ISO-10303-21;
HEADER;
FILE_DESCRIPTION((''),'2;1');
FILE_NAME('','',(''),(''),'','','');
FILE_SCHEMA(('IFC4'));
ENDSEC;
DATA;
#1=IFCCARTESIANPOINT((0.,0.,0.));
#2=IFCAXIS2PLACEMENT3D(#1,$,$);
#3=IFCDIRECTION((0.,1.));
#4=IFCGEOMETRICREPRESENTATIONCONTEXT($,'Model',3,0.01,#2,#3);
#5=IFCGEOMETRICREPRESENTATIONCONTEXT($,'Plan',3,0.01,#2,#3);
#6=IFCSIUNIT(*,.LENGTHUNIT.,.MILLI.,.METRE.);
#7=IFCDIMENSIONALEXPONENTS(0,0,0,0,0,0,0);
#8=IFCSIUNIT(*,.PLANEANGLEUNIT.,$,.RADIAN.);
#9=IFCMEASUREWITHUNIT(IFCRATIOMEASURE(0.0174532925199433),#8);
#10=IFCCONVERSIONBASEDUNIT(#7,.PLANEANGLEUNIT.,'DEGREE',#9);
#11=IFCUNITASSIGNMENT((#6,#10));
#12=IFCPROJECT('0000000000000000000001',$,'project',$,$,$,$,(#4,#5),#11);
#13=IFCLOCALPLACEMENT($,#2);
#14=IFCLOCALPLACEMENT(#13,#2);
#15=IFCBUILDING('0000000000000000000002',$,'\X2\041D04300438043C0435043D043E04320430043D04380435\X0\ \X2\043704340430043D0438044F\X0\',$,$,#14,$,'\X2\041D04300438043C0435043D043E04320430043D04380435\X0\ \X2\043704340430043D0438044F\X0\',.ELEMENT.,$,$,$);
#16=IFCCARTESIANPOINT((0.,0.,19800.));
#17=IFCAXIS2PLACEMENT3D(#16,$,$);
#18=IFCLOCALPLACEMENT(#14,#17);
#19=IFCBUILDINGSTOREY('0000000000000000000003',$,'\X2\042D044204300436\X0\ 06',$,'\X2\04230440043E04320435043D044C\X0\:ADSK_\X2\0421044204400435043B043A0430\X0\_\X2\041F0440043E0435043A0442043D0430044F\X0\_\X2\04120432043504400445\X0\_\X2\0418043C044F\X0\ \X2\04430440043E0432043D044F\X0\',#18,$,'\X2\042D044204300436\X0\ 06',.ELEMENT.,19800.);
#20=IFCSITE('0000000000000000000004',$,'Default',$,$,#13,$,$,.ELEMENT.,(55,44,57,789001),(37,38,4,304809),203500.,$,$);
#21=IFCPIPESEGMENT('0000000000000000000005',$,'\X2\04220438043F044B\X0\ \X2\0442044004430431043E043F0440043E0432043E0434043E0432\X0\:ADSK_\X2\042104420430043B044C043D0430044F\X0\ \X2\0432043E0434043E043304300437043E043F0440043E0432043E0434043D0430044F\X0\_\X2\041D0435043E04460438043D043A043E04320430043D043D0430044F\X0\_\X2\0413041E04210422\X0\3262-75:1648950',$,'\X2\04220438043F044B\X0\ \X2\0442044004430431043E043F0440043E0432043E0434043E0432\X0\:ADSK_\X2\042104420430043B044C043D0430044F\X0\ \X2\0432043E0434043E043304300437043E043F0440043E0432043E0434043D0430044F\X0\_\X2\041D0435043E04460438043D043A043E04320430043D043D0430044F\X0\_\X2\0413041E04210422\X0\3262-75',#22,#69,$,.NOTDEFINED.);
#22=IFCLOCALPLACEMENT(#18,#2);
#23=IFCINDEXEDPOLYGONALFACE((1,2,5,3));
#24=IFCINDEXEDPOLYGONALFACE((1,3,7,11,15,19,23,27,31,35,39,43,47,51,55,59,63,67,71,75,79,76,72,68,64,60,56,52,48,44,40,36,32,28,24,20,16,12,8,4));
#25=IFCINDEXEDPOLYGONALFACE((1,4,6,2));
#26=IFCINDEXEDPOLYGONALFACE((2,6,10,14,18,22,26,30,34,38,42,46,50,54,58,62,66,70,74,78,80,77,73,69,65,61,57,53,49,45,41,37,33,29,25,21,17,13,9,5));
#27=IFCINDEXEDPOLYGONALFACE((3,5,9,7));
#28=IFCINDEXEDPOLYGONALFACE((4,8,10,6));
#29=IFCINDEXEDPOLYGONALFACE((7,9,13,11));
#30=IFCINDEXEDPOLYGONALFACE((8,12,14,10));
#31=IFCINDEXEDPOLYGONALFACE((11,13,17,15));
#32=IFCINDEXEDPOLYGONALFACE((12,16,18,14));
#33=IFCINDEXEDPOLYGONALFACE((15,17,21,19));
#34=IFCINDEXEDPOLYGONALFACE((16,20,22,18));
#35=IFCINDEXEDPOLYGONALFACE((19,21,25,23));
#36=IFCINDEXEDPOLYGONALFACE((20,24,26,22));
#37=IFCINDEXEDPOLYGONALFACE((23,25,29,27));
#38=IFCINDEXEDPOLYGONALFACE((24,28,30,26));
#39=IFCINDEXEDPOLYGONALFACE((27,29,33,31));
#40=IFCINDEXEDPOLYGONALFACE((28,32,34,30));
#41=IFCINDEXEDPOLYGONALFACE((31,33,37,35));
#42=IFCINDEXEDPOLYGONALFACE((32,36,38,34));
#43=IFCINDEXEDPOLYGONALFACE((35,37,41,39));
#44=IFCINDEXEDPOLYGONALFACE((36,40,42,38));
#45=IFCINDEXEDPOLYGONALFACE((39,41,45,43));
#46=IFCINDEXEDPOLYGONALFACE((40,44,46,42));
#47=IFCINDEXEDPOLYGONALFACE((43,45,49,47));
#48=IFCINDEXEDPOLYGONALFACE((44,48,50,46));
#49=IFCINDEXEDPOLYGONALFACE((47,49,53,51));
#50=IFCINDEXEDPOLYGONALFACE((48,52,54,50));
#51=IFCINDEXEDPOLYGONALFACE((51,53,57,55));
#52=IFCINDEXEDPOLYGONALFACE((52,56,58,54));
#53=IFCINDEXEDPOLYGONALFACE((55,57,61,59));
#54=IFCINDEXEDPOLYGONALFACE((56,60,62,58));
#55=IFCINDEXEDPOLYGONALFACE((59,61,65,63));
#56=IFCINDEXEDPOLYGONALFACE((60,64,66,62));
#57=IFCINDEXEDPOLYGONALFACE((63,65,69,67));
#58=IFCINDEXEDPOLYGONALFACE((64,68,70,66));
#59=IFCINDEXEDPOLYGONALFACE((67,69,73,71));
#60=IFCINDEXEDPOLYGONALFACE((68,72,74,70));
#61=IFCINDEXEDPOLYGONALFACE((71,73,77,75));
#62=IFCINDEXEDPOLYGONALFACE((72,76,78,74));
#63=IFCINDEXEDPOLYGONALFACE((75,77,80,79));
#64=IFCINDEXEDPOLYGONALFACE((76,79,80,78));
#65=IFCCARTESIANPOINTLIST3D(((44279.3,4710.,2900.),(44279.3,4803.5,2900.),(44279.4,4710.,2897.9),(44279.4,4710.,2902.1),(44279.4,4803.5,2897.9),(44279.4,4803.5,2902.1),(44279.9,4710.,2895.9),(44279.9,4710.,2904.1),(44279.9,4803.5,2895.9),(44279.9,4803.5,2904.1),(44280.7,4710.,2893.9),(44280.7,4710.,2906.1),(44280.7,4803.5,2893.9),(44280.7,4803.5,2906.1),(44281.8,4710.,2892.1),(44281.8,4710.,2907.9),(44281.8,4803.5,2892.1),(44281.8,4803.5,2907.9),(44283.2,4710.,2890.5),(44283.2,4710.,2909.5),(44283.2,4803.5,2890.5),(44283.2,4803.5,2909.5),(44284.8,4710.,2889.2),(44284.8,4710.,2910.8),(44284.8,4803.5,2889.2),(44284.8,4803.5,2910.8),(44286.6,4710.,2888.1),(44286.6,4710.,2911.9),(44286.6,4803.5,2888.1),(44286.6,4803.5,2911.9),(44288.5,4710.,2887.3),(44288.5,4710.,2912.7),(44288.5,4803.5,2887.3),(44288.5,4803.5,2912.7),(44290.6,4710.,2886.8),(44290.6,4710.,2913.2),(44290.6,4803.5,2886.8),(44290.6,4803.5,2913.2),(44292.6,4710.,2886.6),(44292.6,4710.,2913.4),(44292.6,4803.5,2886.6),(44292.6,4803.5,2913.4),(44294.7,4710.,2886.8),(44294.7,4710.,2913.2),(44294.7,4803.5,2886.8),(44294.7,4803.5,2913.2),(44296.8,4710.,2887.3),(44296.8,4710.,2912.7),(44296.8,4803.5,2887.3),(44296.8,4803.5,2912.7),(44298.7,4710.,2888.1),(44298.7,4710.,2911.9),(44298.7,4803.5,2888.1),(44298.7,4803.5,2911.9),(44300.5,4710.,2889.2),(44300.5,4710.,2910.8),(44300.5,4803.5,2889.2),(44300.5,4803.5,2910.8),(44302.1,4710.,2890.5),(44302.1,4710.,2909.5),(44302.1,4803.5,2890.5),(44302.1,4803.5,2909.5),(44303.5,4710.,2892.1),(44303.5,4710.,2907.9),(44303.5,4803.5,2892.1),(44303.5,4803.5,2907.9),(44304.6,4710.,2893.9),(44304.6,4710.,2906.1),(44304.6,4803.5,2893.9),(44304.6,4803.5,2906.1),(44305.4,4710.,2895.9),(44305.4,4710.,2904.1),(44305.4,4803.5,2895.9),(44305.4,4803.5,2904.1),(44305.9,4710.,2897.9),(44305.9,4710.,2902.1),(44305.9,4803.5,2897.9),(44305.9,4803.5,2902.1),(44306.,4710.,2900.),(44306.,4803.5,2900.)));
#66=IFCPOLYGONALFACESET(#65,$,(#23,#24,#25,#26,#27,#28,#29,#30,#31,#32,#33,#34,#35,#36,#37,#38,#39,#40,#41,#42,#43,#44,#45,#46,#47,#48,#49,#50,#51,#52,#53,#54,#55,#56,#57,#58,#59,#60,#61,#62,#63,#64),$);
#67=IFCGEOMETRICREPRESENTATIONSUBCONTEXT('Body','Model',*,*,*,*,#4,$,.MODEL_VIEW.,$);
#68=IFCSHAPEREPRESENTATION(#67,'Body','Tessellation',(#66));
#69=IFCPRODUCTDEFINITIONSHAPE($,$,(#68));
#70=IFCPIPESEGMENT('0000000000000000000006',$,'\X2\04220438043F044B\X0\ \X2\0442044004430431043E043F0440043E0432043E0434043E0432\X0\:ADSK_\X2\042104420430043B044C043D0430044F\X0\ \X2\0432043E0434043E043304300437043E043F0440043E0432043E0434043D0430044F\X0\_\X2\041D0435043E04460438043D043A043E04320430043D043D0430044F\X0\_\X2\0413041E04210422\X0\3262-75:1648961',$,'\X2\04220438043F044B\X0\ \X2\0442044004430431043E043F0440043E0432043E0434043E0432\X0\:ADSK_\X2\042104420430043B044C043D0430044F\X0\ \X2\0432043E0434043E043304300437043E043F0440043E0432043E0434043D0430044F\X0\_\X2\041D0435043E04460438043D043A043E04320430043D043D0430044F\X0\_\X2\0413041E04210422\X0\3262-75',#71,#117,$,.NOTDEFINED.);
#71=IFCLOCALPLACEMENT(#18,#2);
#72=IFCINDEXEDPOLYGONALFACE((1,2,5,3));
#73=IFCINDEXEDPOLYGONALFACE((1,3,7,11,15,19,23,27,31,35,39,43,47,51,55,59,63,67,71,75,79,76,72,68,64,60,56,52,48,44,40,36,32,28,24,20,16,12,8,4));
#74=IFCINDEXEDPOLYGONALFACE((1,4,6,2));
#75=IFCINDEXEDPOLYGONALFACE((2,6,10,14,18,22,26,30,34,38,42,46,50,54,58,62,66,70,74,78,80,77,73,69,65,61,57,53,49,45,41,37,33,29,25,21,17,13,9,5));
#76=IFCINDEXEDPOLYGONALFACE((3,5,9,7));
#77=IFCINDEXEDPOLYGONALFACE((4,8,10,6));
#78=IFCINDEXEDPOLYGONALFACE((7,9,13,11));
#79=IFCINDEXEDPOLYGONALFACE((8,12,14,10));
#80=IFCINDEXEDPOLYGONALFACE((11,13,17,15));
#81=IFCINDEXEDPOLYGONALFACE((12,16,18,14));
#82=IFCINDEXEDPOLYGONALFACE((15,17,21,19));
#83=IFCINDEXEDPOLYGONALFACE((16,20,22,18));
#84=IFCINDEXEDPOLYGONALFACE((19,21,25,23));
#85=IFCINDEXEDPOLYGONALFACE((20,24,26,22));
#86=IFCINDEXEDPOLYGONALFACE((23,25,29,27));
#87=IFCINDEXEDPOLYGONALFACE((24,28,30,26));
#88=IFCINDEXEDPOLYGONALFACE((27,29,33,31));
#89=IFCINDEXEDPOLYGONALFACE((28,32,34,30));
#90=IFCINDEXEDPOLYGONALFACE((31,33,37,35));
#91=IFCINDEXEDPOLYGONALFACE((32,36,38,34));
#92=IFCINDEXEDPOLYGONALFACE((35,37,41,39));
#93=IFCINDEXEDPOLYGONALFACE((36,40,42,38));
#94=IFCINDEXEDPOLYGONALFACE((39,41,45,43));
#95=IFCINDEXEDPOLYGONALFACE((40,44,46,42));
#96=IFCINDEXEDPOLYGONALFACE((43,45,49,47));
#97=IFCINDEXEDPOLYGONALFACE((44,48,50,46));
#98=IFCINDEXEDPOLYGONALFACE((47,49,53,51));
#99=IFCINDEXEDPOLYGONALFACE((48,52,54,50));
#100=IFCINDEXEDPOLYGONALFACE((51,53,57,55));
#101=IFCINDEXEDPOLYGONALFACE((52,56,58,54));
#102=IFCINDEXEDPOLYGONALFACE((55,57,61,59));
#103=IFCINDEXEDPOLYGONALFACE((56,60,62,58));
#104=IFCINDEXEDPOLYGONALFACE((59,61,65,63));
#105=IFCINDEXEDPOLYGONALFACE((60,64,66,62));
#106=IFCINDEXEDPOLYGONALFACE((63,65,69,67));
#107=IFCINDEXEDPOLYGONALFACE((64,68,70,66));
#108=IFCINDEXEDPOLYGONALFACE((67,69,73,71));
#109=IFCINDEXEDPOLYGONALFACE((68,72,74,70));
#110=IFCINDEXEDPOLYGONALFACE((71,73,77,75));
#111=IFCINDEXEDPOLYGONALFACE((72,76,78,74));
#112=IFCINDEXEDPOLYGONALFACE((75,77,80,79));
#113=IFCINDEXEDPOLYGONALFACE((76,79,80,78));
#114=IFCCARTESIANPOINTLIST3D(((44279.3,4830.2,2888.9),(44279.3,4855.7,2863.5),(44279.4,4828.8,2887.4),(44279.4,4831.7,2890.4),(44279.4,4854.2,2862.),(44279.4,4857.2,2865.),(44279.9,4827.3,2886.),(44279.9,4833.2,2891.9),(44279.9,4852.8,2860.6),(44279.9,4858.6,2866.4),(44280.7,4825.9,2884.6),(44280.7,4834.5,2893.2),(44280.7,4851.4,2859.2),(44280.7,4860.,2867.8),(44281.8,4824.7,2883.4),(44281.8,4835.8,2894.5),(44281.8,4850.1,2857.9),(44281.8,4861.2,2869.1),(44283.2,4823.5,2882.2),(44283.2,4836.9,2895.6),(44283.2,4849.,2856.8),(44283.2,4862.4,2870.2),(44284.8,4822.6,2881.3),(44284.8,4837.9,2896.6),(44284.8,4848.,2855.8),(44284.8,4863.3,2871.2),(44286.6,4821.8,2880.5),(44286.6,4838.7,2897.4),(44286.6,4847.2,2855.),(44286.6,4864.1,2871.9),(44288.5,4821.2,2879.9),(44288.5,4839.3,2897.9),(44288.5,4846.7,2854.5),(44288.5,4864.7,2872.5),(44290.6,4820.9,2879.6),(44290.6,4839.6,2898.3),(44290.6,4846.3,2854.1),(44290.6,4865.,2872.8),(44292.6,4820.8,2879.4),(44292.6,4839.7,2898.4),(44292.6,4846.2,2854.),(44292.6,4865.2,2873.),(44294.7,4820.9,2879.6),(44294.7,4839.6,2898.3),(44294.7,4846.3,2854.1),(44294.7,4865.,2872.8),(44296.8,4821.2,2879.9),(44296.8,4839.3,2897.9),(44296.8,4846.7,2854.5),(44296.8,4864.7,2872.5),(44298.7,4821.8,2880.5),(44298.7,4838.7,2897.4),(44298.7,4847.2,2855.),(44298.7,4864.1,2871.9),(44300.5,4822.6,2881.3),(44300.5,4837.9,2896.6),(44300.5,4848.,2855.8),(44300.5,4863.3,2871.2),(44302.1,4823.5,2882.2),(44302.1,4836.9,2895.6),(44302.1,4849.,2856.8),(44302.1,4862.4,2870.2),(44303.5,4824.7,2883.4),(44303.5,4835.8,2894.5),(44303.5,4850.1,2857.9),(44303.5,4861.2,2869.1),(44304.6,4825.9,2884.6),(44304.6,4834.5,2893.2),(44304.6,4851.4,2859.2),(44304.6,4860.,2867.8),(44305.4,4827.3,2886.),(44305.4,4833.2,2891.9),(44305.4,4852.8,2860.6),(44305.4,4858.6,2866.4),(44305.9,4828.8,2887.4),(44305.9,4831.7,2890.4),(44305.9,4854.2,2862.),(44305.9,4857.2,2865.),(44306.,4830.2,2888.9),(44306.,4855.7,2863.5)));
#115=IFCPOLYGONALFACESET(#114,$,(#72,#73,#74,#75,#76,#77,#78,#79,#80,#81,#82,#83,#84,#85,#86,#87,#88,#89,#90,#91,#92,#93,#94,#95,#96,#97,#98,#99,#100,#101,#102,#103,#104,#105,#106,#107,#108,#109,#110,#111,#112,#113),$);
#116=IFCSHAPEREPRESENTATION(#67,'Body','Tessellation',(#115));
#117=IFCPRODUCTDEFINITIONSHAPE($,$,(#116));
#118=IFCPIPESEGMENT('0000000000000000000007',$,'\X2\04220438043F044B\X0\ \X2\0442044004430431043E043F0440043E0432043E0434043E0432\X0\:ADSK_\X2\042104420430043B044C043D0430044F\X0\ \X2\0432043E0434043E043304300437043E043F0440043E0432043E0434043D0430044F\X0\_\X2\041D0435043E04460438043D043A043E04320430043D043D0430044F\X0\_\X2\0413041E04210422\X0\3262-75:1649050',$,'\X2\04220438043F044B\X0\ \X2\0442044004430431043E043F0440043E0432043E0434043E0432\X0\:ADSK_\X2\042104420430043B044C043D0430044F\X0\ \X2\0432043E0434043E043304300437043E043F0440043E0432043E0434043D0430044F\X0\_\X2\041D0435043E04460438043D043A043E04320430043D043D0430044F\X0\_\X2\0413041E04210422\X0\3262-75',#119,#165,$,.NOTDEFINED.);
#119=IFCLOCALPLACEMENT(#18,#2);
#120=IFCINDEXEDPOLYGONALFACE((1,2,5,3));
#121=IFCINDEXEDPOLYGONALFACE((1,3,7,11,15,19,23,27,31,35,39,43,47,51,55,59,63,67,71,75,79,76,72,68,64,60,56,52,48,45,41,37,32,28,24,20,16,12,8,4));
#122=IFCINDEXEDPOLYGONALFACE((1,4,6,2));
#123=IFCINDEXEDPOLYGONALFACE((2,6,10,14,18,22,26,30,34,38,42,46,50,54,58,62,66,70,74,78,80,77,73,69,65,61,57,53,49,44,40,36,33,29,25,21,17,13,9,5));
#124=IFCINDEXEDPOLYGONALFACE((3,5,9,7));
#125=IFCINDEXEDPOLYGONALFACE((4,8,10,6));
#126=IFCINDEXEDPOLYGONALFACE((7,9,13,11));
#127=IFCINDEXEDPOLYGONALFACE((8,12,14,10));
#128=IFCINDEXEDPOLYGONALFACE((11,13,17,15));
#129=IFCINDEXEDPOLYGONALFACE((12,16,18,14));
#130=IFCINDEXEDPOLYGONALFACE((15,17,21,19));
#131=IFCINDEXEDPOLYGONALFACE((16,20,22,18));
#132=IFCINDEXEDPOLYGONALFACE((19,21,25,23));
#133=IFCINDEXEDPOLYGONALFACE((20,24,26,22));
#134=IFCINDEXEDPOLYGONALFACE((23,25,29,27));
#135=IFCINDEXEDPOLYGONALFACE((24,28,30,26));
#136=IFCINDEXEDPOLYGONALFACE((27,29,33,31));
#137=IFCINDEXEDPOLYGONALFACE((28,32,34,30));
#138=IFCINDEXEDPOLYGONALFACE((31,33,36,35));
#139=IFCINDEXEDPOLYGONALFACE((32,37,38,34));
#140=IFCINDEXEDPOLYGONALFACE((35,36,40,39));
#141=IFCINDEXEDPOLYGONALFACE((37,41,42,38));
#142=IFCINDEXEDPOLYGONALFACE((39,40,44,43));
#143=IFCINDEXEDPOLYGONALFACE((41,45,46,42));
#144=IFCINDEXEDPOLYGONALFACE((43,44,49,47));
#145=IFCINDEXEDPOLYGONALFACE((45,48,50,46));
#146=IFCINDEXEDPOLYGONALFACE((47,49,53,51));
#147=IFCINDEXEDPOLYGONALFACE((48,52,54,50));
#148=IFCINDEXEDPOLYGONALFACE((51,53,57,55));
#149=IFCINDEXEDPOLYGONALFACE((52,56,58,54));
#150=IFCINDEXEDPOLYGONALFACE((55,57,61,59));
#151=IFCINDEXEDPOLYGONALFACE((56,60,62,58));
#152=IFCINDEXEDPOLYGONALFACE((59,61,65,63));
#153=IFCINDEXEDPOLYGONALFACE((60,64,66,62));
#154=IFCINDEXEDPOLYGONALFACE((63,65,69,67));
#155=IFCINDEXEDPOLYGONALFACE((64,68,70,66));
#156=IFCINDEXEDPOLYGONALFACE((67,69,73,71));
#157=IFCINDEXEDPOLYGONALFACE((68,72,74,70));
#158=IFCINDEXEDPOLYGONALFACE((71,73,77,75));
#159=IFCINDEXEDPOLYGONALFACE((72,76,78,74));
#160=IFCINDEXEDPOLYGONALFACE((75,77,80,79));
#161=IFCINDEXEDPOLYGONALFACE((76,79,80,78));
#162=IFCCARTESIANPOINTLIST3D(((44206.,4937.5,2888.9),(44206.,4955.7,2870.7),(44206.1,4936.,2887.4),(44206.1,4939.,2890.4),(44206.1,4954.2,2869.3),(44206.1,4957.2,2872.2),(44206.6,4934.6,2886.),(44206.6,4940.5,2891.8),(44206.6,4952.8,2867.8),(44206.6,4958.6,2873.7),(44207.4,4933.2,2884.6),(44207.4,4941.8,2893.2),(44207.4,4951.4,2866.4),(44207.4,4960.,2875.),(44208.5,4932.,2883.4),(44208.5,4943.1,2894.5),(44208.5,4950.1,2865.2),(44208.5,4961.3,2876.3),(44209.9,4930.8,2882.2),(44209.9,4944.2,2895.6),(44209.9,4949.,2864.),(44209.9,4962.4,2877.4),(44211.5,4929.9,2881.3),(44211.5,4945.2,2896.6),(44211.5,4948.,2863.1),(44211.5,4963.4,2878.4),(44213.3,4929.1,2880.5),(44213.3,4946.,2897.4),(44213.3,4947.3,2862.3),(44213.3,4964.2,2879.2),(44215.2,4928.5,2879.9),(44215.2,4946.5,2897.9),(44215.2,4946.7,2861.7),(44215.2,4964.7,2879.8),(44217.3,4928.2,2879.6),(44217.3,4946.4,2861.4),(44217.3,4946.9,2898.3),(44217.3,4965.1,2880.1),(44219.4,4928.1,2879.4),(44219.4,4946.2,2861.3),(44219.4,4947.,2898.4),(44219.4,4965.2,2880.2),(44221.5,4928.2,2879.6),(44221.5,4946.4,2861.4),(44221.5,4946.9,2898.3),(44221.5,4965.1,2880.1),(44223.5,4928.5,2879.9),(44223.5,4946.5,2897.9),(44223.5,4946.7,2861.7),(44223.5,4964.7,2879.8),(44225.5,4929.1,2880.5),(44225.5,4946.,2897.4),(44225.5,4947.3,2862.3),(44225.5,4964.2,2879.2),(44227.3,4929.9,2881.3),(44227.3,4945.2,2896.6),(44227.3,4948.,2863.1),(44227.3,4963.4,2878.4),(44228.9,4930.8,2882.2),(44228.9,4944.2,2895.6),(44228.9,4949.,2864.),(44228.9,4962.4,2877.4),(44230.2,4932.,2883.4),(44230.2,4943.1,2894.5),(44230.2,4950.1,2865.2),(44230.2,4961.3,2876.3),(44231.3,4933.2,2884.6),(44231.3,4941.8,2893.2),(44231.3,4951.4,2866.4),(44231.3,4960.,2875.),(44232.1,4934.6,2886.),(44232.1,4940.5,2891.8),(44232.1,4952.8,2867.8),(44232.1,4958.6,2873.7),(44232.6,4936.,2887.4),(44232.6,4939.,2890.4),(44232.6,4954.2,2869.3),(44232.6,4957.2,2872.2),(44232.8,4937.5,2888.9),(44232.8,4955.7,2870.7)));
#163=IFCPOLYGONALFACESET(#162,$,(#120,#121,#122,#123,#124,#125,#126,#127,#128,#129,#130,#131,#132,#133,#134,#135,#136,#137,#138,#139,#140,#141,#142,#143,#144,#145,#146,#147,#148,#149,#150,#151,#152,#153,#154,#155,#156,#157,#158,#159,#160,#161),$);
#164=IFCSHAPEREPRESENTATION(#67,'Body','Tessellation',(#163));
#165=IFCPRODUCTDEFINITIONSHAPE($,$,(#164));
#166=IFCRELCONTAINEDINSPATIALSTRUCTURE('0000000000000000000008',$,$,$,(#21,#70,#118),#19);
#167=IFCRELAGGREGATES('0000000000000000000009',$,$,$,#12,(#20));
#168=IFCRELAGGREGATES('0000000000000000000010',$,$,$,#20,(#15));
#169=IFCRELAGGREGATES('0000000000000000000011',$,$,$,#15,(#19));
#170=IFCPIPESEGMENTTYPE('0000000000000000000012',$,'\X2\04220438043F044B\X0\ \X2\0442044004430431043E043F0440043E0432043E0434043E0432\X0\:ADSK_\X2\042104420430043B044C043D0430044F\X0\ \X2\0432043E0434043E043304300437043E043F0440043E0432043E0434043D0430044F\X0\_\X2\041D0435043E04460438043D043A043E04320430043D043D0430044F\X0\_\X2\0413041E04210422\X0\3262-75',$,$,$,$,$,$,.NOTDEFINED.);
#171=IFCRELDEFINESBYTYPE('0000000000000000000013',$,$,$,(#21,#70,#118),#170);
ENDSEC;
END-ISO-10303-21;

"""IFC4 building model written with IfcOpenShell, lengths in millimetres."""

from ifc_helpers import new_model, entity, si_unit, converted_unit, direction, frame, origin, place, context, subcontext, project, spatial, indexed_curve, outline, extrude, type_object, element, save


model = new_model("IFC4")

# Units and contexts
model_context = context("Model", 3, precision=0.01, world=origin(), true_north=direction((0.0, 1.0)))
plan_context = context("Plan", 3, precision=0.01, world=origin(), true_north=direction((0.0, 1.0)))
body_context = subcontext(model_context, "Body", "Model", "MODEL_VIEW")
ifc_project = project(units=[si_unit("LENGTHUNIT", "METRE", prefix="MILLI"), converted_unit("PLANEANGLEUNIT", "DEGREE", entity("IfcRatioMeasure", 0.0174532925199433), si_unit("PLANEANGLEUNIT", "RADIAN"), dimensions=[0, 0, 0, 0, 0, 0, 0])], contexts=[model_context, plan_context])

# Site, building, storey
site_placement = place(None, origin())
site = spatial("IfcSite", under=ifc_project, at=site_placement, Name="Default", CompositionType="ELEMENT", RefLatitude=(55, 44, 57, 789001), RefLongitude=(37, 38, 4, 304809), RefElevation=203500.0)
building_placement = place(site_placement, origin())
building = spatial("IfcBuilding", under=site, at=building_placement, Name="Наименование здания", LongName="Наименование здания", CompositionType="ELEMENT")
storey_placement = place(building_placement, frame((0.0, 0.0, 19800.0)))
storey = spatial("IfcBuildingStorey", under=building, at=storey_placement, Name="Этаж 06", ObjectType="Уровень:ADSK_Стрелка_Проектная_Вверх_Имя уровня", LongName="Этаж 06", CompositionType="ELEMENT", Elevation=19800.0)

# Pipe segments
pipe_segment_type = type_object("IfcPipeSegmentType", Name="Типы трубопроводов:ADSK_Стальная водогазопроводная_Неоцинкованная_ГОСТ3262-75", PredefinedType="NOTDEFINED")
placement = place(storey_placement, origin())
element("IfcPipeSegment", 1, at=placement, inside=storey, type_object=pipe_segment_type, Name="Типы трубопроводов:ADSK_Стальная водогазопроводная_Неоцинкованная_ГОСТ3262-75:1648950", ObjectType="Типы трубопроводов:ADSK_Стальная водогазопроводная_Неоцинкованная_ГОСТ3262-75", PredefinedType="NOTDEFINED", context=body_context, shape_type="SweptSolid", body=[
    extrude(outline(indexed_curve([(13.4, 0.0), (13.2, 2.1), (12.7, 4.1), (11.9, 6.1), (10.8, 7.9), (9.5, 9.5), (7.9, 10.8), (6.1, 11.9), (4.1, 12.7), (2.1, 13.2), (0.0, 13.4), (-2.1, 13.2), (-4.1, 12.7), (-6.1, 11.9), (-7.9, 10.8), (-9.5, 9.5), (-10.8, 7.9), (-11.9, 6.1), (-12.7, 4.1), (-13.2, 2.1), (-13.4, 0.0), (-13.2, -2.1), (-12.7, -4.1), (-11.9, -6.1), (-10.8, -7.9), (-9.5, -9.5), (-7.9, -10.8), (-6.1, -11.9), (-4.1, -12.7), (-2.1, -13.2), (0.0, -13.4), (2.1, -13.2), (4.1, -12.7), (6.1, -11.9), (7.9, -10.8), (9.5, -9.5), (10.8, -7.9), (11.9, -6.1), (12.7, -4.1), (13.2, -2.1), (13.4, 0.0)], self_intersect=False)), frame((44292.7, 4710.0, 2900.0), z_axis=(0.0, 1.0, 0.0), x_axis=(1.0, 0.0, 0.0)), (0.0, 0.0, 1.0), 93.5),
])
element("IfcPipeSegment", 2, at=placement, inside=storey, type_object=pipe_segment_type, Name="Типы трубопроводов:ADSK_Стальная водогазопроводная_Неоцинкованная_ГОСТ3262-75:1648961", ObjectType="Типы трубопроводов:ADSK_Стальная водогазопроводная_Неоцинкованная_ГОСТ3262-75", PredefinedType="NOTDEFINED", context=body_context, shape_type="SweptSolid", body=[
    extrude(outline(indexed_curve([(13.4, 0.0), (13.2, 2.1), (12.7, 4.1), (11.9, 6.1), (10.8, 7.9), (9.5, 9.5), (7.9, 10.8), (6.1, 11.9), (4.1, 12.7), (2.1, 13.2), (0.0, 13.4), (-2.1, 13.2), (-4.1, 12.7), (-6.1, 11.9), (-7.9, 10.8), (-9.5, 9.5), (-10.8, 7.9), (-11.9, 6.1), (-12.7, 4.1), (-13.2, 2.1), (-13.4, 0.0), (-13.2, -2.1), (-12.7, -4.1), (-11.9, -6.1), (-10.8, -7.9), (-9.5, -9.5), (-7.9, -10.8), (-6.1, -11.9), (-4.1, -12.7), (-2.1, -13.2), (0.0, -13.4), (2.1, -13.2), (4.1, -12.7), (6.1, -11.9), (7.9, -10.8), (9.5, -9.5), (10.8, -7.9), (11.9, -6.1), (12.7, -4.1), (13.2, -2.1), (13.4, 0.0)], self_intersect=False)), frame((44292.7, 4855.7, 2863.5), z_axis=(0.0, -0.707107, 0.707107), x_axis=(1.0, 0.0, 0.0)), (0.0, 0.0, 1.0), 36.0),
])
element("IfcPipeSegment", 3, at=placement, inside=storey, type_object=pipe_segment_type, Name="Типы трубопроводов:ADSK_Стальная водогазопроводная_Неоцинкованная_ГОСТ3262-75:1649050", ObjectType="Типы трубопроводов:ADSK_Стальная водогазопроводная_Неоцинкованная_ГОСТ3262-75", PredefinedType="NOTDEFINED", context=body_context, shape_type="SweptSolid", body=[
    extrude(outline(indexed_curve([(13.4, 0.0), (13.2, 2.1), (12.7, 4.1), (11.9, 6.1), (10.8, 7.9), (9.5, 9.5), (7.9, 10.8), (6.1, 11.9), (4.1, 12.7), (2.1, 13.2), (0.0, 13.4), (-2.1, 13.2), (-4.1, 12.7), (-6.1, 11.9), (-7.9, 10.8), (-9.5, 9.5), (-10.8, 7.9), (-11.9, 6.1), (-12.7, 4.1), (-13.2, 2.1), (-13.4, 0.0), (-13.2, -2.1), (-12.7, -4.1), (-11.9, -6.1), (-10.8, -7.9), (-9.5, -9.5), (-7.9, -10.8), (-6.1, -11.9), (-4.1, -12.7), (-2.1, -13.2), (0.0, -13.4), (2.1, -13.2), (4.1, -12.7), (6.1, -11.9), (7.9, -10.8), (9.5, -9.5), (10.8, -7.9), (11.9, -6.1), (12.7, -4.1), (13.2, -2.1), (13.4, 0.0)], self_intersect=False)), frame((44219.4, 4955.7, 2870.7), z_axis=(0.0, -0.707107, 0.707107), x_axis=(-1.0, 0.0, 0.0)), (0.0, 0.0, 1.0), 25.7),
])

save(model, "model.ifc")
